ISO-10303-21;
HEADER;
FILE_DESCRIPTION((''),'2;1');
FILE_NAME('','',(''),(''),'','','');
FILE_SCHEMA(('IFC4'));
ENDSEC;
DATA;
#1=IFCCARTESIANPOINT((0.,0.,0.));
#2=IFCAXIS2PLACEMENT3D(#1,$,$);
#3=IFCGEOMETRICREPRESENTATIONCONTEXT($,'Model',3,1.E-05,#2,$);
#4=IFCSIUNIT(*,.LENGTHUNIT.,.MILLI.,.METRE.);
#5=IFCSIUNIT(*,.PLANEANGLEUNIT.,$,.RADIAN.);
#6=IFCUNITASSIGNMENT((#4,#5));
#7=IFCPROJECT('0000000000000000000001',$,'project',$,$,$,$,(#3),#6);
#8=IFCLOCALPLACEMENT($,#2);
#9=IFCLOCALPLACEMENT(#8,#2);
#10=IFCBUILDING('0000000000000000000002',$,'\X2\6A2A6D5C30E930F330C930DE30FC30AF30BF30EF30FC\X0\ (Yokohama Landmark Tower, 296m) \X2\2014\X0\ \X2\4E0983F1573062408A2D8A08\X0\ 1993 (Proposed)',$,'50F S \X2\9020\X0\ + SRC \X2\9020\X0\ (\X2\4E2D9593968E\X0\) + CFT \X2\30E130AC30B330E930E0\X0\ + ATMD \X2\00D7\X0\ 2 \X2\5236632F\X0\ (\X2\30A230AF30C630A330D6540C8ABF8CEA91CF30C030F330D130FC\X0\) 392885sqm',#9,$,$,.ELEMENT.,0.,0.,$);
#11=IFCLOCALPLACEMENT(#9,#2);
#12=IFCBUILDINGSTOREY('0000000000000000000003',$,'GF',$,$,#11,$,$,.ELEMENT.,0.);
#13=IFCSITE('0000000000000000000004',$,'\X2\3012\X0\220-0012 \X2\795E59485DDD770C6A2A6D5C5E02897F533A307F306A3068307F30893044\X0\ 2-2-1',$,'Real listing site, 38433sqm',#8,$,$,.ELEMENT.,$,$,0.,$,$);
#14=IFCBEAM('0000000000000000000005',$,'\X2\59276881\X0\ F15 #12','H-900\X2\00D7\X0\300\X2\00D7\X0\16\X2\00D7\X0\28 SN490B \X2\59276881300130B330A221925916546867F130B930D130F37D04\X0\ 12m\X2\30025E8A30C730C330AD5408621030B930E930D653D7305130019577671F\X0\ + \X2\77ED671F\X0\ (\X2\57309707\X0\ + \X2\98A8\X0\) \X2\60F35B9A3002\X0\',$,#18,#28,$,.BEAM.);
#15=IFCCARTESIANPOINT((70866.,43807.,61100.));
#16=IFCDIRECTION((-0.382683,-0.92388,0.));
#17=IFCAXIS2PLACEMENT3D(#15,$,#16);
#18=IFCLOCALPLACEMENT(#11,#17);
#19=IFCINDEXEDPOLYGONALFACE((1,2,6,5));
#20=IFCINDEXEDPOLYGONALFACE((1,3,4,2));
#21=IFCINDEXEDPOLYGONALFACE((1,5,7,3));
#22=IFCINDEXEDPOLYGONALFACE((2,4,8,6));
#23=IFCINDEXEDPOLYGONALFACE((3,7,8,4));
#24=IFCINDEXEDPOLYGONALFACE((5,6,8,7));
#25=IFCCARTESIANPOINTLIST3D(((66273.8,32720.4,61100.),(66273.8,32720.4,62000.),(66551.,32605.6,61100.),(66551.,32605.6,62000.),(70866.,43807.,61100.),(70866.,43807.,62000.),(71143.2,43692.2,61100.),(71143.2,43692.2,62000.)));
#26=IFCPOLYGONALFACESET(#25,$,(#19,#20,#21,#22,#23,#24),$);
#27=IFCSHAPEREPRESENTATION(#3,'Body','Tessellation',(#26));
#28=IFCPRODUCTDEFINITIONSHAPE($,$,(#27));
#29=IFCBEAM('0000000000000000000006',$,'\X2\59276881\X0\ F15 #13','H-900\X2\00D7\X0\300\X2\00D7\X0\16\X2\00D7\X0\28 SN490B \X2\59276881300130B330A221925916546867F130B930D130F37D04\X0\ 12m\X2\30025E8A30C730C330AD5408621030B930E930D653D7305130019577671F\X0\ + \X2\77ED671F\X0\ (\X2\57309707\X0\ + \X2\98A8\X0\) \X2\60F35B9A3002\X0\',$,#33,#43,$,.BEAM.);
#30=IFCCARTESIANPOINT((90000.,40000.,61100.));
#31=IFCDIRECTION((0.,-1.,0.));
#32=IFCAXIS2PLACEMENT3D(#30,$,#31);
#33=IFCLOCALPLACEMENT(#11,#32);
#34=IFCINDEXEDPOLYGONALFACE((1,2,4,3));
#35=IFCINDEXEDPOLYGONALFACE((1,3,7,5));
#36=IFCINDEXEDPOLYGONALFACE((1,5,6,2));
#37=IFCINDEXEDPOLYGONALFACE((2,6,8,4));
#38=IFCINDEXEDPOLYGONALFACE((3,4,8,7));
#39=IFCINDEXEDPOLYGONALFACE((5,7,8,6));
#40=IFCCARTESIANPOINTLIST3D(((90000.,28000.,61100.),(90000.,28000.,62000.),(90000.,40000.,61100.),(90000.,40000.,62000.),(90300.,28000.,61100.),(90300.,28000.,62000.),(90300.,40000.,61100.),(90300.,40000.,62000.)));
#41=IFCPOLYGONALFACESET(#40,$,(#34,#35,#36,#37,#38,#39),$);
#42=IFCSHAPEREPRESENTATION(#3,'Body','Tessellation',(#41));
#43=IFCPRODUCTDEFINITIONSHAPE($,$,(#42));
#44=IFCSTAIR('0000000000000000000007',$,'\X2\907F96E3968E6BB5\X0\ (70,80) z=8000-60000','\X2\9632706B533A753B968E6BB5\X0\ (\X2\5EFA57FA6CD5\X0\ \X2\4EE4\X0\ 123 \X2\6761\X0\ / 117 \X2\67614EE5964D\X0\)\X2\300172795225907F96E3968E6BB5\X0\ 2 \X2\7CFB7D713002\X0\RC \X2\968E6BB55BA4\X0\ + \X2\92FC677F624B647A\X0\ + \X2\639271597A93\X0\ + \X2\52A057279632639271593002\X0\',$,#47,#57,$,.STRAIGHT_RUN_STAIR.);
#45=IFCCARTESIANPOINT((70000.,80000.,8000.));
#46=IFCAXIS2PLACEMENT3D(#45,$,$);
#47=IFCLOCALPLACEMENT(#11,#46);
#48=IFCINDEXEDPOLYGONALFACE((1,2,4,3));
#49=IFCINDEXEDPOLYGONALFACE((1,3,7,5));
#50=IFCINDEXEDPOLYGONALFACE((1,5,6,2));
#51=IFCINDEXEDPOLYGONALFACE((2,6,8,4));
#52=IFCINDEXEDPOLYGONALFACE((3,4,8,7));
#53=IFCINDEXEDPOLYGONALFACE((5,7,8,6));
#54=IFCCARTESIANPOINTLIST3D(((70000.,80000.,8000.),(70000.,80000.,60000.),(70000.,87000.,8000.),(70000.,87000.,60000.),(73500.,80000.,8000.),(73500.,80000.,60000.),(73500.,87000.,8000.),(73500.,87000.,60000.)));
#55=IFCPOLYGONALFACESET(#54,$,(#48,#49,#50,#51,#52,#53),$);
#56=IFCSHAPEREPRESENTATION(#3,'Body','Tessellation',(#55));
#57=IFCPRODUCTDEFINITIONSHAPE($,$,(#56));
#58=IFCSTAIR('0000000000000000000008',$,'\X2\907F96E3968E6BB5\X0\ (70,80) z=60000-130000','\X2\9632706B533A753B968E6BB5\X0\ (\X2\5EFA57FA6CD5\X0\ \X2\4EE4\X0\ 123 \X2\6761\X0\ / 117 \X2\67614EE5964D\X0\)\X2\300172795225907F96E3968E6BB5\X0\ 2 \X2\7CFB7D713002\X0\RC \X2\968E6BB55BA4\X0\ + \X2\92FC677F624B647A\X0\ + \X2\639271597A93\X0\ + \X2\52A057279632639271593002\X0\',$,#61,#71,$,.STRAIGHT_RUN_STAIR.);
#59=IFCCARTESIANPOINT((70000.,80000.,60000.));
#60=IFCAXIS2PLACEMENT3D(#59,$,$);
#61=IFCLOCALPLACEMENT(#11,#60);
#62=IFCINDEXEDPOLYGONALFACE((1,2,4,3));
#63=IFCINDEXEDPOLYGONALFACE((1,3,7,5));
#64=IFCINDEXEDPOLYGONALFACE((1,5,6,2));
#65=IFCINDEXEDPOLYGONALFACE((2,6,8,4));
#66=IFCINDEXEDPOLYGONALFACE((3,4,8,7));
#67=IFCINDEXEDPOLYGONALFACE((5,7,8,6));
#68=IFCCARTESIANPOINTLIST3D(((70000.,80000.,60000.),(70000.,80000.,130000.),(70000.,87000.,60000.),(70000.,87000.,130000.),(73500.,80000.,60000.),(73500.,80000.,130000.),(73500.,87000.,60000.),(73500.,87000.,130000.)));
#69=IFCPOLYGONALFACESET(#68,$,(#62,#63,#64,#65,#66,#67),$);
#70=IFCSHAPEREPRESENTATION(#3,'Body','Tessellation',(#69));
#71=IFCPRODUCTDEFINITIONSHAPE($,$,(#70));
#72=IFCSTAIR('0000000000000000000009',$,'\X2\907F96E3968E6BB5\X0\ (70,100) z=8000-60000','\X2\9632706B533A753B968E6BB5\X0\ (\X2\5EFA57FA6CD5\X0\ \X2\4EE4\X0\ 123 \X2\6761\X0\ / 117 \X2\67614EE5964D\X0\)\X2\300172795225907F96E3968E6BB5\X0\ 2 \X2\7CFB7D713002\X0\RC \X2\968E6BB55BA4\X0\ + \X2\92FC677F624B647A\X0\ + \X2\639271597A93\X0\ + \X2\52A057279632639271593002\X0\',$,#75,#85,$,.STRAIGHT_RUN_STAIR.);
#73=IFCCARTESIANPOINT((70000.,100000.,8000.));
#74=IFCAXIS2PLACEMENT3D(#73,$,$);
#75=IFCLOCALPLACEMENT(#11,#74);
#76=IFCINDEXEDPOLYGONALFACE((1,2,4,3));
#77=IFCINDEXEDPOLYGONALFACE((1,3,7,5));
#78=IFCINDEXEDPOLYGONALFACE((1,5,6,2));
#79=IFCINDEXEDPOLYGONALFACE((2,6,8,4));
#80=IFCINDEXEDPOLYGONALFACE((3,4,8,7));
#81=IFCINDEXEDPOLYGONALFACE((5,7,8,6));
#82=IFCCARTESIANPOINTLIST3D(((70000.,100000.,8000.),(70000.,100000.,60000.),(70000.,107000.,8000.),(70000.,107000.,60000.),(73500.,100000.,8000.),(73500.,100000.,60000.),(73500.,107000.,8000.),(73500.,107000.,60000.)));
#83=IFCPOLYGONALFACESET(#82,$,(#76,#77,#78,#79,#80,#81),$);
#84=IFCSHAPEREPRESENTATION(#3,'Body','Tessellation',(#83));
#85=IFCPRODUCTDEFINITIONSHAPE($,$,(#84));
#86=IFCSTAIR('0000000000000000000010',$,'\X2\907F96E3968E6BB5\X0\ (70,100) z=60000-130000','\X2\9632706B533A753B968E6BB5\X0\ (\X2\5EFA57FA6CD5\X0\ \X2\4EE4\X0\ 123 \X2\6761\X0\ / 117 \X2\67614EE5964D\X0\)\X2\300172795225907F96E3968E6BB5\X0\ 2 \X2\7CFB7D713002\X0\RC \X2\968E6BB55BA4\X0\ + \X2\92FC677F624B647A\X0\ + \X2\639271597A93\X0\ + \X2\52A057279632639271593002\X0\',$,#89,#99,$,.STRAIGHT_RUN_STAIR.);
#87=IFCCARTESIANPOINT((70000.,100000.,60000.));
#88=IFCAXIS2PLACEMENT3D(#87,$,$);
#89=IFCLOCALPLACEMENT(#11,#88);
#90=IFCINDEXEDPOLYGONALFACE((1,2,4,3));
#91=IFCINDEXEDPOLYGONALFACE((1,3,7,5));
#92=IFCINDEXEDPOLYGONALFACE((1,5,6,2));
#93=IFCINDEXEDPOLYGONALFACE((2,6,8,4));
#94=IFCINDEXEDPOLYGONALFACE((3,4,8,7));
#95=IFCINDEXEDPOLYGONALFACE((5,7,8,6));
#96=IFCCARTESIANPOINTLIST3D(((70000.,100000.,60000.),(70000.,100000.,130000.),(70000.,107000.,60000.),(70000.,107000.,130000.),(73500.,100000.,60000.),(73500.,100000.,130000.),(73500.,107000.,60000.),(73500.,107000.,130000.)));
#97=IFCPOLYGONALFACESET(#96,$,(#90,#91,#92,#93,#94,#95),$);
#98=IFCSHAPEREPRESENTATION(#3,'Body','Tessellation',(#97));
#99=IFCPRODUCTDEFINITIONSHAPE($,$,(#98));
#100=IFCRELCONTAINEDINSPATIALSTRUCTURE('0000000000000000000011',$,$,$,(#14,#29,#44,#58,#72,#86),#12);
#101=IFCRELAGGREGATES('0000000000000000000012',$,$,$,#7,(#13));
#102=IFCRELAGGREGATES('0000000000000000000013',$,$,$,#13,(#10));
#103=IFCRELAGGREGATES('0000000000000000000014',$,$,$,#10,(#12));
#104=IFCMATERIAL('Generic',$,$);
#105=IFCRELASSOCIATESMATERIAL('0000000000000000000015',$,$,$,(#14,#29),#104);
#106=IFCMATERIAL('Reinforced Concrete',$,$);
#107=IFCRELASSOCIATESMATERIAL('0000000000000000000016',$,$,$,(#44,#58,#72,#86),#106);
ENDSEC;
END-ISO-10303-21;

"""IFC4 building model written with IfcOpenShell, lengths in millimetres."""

from ifc_helpers import new_model, si_unit, frame, frame_2d, origin, place, context, project, spatial, rectangle, extrude, material, element, save


model = new_model("IFC4")

# Units and contexts
model_context = context("Model", 3, precision=1e-05, world=origin())
ifc_project = project(units=[si_unit("LENGTHUNIT", "METRE", prefix="MILLI"), si_unit("PLANEANGLEUNIT", "RADIAN")], contexts=[model_context])

# Site, building, storey
site_placement = place(None, origin())
site = spatial("IfcSite", under=ifc_project, at=site_placement, Name="〒220-0012 神奈川県横浜市西区みなとみらい 2-2-1", ObjectType="Real listing site, 38433sqm", CompositionType="ELEMENT", RefElevation=0.0)
building_placement = place(site_placement, origin())
building = spatial("IfcBuilding", under=site, at=building_placement, Name="横浜ランドマークタワー (Yokohama Landmark Tower, 296m) — 三菱地所設計 1993 (Proposed)", ObjectType="50F S 造 + SRC 造 (中間階) + CFT メガコラム + ATMD × 2 制振 (アクティブ同調質量ダンパー) 392885sqm", CompositionType="ELEMENT", ElevationOfRefHeight=0.0, ElevationOfTerrain=0.0)
storey_placement = place(building_placement, origin())
storey = spatial("IfcBuildingStorey", under=building, at=storey_placement, Name="GF", CompositionType="ELEMENT", Elevation=0.0)

# Shared definitions
ifc_material_1 = material(Name="Reinforced Concrete")

# Beams
ifc_material_2 = material(Name="Generic")
beam_1_placement = place(storey_placement, frame((70866.0, 43807.0, 61100.0), x_axis=(-0.382683, -0.92388, 0.0)))
element("IfcBeam", 1, at=beam_1_placement, inside=storey, material=ifc_material_2, Name="大梁 F15 #12", Description="H-900×300×16×28 SN490B 大梁、コア→外周柱スパン約 12m。床デッキ合成スラブ受け、長期 + 短期 (地震 + 風) 想定。", PredefinedType="BEAM", context=model_context, shape_type="SweptSolid", body=[
    extrude(rectangle(XDim=12000.0, YDim=300.0, at=frame_2d((6000.0, 150.0))), frame((70866.0, 43807.0, 61100.0), x_axis=(-0.382683, -0.92388, 0.0)), (0.0, 0.0, 1.0), 900.0),
])
beam_2_placement = place(storey_placement, frame((90000.0, 40000.0, 61100.0), x_axis=(0.0, -1.0, 0.0)))
element("IfcBeam", 2, at=beam_2_placement, inside=storey, material=ifc_material_2, Name="大梁 F15 #13", Description="H-900×300×16×28 SN490B 大梁、コア→外周柱スパン約 12m。床デッキ合成スラブ受け、長期 + 短期 (地震 + 風) 想定。", PredefinedType="BEAM", context=model_context, shape_type="SweptSolid", body=[
    extrude(rectangle(XDim=12000.0, YDim=300.0, at=frame_2d((6000.0, 150.0))), frame((90000.0, 40000.0, 61100.0), x_axis=(0.0, -1.0, 0.0)), (0.0, 0.0, 1.0), 900.0),
])

# Stairs
stair_1_placement = place(storey_placement, frame((70000.0, 80000.0, 8000.0)))
element("IfcStair", 3, at=stair_1_placement, inside=storey, material=ifc_material_1, Name="避難階段 (70,80) z=8000-60000", Description="防火区画階段 (建基法 令 123 条 / 117 条以降)、特別避難階段 2 系統。RC 階段室 + 鋼板手摺 + 排煙窓 + 加圧防排煙。", PredefinedType="STRAIGHT_RUN_STAIR", context=model_context, shape_type="SweptSolid", body=[
    extrude(rectangle(XDim=3500.0, YDim=7000.0, at=frame_2d((1750.0, 3500.0))), frame((70000.0, 80000.0, 8000.0)), (0.0, 0.0, 1.0), 52000.0),
])
stair_2_placement = place(storey_placement, frame((70000.0, 80000.0, 60000.0)))
element("IfcStair", 4, at=stair_2_placement, inside=storey, material=ifc_material_1, Name="避難階段 (70,80) z=60000-130000", Description="防火区画階段 (建基法 令 123 条 / 117 条以降)、特別避難階段 2 系統。RC 階段室 + 鋼板手摺 + 排煙窓 + 加圧防排煙。", PredefinedType="STRAIGHT_RUN_STAIR", context=model_context, shape_type="SweptSolid", body=[
    extrude(rectangle(XDim=3500.0, YDim=7000.0, at=frame_2d((1750.0, 3500.0))), frame((70000.0, 80000.0, 60000.0)), (0.0, 0.0, 1.0), 70000.0),
])
stair_3_placement = place(storey_placement, frame((70000.0, 100000.0, 8000.0)))
element("IfcStair", 5, at=stair_3_placement, inside=storey, material=ifc_material_1, Name="避難階段 (70,100) z=8000-60000", Description="防火区画階段 (建基法 令 123 条 / 117 条以降)、特別避難階段 2 系統。RC 階段室 + 鋼板手摺 + 排煙窓 + 加圧防排煙。", PredefinedType="STRAIGHT_RUN_STAIR", context=model_context, shape_type="SweptSolid", body=[
    extrude(rectangle(XDim=3500.0, YDim=7000.0, at=frame_2d((1750.0, 3500.0))), frame((70000.0, 100000.0, 8000.0)), (0.0, 0.0, 1.0), 52000.0),
])
stair_4_placement = place(storey_placement, frame((70000.0, 100000.0, 60000.0)))
element("IfcStair", 6, at=stair_4_placement, inside=storey, material=ifc_material_1, Name="避難階段 (70,100) z=60000-130000", Description="防火区画階段 (建基法 令 123 条 / 117 条以降)、特別避難階段 2 系統。RC 階段室 + 鋼板手摺 + 排煙窓 + 加圧防排煙。", PredefinedType="STRAIGHT_RUN_STAIR", context=model_context, shape_type="SweptSolid", body=[
    extrude(rectangle(XDim=3500.0, YDim=7000.0, at=frame_2d((1750.0, 3500.0))), frame((70000.0, 100000.0, 60000.0)), (0.0, 0.0, 1.0), 70000.0),
])

save(model, "model.ifc")
